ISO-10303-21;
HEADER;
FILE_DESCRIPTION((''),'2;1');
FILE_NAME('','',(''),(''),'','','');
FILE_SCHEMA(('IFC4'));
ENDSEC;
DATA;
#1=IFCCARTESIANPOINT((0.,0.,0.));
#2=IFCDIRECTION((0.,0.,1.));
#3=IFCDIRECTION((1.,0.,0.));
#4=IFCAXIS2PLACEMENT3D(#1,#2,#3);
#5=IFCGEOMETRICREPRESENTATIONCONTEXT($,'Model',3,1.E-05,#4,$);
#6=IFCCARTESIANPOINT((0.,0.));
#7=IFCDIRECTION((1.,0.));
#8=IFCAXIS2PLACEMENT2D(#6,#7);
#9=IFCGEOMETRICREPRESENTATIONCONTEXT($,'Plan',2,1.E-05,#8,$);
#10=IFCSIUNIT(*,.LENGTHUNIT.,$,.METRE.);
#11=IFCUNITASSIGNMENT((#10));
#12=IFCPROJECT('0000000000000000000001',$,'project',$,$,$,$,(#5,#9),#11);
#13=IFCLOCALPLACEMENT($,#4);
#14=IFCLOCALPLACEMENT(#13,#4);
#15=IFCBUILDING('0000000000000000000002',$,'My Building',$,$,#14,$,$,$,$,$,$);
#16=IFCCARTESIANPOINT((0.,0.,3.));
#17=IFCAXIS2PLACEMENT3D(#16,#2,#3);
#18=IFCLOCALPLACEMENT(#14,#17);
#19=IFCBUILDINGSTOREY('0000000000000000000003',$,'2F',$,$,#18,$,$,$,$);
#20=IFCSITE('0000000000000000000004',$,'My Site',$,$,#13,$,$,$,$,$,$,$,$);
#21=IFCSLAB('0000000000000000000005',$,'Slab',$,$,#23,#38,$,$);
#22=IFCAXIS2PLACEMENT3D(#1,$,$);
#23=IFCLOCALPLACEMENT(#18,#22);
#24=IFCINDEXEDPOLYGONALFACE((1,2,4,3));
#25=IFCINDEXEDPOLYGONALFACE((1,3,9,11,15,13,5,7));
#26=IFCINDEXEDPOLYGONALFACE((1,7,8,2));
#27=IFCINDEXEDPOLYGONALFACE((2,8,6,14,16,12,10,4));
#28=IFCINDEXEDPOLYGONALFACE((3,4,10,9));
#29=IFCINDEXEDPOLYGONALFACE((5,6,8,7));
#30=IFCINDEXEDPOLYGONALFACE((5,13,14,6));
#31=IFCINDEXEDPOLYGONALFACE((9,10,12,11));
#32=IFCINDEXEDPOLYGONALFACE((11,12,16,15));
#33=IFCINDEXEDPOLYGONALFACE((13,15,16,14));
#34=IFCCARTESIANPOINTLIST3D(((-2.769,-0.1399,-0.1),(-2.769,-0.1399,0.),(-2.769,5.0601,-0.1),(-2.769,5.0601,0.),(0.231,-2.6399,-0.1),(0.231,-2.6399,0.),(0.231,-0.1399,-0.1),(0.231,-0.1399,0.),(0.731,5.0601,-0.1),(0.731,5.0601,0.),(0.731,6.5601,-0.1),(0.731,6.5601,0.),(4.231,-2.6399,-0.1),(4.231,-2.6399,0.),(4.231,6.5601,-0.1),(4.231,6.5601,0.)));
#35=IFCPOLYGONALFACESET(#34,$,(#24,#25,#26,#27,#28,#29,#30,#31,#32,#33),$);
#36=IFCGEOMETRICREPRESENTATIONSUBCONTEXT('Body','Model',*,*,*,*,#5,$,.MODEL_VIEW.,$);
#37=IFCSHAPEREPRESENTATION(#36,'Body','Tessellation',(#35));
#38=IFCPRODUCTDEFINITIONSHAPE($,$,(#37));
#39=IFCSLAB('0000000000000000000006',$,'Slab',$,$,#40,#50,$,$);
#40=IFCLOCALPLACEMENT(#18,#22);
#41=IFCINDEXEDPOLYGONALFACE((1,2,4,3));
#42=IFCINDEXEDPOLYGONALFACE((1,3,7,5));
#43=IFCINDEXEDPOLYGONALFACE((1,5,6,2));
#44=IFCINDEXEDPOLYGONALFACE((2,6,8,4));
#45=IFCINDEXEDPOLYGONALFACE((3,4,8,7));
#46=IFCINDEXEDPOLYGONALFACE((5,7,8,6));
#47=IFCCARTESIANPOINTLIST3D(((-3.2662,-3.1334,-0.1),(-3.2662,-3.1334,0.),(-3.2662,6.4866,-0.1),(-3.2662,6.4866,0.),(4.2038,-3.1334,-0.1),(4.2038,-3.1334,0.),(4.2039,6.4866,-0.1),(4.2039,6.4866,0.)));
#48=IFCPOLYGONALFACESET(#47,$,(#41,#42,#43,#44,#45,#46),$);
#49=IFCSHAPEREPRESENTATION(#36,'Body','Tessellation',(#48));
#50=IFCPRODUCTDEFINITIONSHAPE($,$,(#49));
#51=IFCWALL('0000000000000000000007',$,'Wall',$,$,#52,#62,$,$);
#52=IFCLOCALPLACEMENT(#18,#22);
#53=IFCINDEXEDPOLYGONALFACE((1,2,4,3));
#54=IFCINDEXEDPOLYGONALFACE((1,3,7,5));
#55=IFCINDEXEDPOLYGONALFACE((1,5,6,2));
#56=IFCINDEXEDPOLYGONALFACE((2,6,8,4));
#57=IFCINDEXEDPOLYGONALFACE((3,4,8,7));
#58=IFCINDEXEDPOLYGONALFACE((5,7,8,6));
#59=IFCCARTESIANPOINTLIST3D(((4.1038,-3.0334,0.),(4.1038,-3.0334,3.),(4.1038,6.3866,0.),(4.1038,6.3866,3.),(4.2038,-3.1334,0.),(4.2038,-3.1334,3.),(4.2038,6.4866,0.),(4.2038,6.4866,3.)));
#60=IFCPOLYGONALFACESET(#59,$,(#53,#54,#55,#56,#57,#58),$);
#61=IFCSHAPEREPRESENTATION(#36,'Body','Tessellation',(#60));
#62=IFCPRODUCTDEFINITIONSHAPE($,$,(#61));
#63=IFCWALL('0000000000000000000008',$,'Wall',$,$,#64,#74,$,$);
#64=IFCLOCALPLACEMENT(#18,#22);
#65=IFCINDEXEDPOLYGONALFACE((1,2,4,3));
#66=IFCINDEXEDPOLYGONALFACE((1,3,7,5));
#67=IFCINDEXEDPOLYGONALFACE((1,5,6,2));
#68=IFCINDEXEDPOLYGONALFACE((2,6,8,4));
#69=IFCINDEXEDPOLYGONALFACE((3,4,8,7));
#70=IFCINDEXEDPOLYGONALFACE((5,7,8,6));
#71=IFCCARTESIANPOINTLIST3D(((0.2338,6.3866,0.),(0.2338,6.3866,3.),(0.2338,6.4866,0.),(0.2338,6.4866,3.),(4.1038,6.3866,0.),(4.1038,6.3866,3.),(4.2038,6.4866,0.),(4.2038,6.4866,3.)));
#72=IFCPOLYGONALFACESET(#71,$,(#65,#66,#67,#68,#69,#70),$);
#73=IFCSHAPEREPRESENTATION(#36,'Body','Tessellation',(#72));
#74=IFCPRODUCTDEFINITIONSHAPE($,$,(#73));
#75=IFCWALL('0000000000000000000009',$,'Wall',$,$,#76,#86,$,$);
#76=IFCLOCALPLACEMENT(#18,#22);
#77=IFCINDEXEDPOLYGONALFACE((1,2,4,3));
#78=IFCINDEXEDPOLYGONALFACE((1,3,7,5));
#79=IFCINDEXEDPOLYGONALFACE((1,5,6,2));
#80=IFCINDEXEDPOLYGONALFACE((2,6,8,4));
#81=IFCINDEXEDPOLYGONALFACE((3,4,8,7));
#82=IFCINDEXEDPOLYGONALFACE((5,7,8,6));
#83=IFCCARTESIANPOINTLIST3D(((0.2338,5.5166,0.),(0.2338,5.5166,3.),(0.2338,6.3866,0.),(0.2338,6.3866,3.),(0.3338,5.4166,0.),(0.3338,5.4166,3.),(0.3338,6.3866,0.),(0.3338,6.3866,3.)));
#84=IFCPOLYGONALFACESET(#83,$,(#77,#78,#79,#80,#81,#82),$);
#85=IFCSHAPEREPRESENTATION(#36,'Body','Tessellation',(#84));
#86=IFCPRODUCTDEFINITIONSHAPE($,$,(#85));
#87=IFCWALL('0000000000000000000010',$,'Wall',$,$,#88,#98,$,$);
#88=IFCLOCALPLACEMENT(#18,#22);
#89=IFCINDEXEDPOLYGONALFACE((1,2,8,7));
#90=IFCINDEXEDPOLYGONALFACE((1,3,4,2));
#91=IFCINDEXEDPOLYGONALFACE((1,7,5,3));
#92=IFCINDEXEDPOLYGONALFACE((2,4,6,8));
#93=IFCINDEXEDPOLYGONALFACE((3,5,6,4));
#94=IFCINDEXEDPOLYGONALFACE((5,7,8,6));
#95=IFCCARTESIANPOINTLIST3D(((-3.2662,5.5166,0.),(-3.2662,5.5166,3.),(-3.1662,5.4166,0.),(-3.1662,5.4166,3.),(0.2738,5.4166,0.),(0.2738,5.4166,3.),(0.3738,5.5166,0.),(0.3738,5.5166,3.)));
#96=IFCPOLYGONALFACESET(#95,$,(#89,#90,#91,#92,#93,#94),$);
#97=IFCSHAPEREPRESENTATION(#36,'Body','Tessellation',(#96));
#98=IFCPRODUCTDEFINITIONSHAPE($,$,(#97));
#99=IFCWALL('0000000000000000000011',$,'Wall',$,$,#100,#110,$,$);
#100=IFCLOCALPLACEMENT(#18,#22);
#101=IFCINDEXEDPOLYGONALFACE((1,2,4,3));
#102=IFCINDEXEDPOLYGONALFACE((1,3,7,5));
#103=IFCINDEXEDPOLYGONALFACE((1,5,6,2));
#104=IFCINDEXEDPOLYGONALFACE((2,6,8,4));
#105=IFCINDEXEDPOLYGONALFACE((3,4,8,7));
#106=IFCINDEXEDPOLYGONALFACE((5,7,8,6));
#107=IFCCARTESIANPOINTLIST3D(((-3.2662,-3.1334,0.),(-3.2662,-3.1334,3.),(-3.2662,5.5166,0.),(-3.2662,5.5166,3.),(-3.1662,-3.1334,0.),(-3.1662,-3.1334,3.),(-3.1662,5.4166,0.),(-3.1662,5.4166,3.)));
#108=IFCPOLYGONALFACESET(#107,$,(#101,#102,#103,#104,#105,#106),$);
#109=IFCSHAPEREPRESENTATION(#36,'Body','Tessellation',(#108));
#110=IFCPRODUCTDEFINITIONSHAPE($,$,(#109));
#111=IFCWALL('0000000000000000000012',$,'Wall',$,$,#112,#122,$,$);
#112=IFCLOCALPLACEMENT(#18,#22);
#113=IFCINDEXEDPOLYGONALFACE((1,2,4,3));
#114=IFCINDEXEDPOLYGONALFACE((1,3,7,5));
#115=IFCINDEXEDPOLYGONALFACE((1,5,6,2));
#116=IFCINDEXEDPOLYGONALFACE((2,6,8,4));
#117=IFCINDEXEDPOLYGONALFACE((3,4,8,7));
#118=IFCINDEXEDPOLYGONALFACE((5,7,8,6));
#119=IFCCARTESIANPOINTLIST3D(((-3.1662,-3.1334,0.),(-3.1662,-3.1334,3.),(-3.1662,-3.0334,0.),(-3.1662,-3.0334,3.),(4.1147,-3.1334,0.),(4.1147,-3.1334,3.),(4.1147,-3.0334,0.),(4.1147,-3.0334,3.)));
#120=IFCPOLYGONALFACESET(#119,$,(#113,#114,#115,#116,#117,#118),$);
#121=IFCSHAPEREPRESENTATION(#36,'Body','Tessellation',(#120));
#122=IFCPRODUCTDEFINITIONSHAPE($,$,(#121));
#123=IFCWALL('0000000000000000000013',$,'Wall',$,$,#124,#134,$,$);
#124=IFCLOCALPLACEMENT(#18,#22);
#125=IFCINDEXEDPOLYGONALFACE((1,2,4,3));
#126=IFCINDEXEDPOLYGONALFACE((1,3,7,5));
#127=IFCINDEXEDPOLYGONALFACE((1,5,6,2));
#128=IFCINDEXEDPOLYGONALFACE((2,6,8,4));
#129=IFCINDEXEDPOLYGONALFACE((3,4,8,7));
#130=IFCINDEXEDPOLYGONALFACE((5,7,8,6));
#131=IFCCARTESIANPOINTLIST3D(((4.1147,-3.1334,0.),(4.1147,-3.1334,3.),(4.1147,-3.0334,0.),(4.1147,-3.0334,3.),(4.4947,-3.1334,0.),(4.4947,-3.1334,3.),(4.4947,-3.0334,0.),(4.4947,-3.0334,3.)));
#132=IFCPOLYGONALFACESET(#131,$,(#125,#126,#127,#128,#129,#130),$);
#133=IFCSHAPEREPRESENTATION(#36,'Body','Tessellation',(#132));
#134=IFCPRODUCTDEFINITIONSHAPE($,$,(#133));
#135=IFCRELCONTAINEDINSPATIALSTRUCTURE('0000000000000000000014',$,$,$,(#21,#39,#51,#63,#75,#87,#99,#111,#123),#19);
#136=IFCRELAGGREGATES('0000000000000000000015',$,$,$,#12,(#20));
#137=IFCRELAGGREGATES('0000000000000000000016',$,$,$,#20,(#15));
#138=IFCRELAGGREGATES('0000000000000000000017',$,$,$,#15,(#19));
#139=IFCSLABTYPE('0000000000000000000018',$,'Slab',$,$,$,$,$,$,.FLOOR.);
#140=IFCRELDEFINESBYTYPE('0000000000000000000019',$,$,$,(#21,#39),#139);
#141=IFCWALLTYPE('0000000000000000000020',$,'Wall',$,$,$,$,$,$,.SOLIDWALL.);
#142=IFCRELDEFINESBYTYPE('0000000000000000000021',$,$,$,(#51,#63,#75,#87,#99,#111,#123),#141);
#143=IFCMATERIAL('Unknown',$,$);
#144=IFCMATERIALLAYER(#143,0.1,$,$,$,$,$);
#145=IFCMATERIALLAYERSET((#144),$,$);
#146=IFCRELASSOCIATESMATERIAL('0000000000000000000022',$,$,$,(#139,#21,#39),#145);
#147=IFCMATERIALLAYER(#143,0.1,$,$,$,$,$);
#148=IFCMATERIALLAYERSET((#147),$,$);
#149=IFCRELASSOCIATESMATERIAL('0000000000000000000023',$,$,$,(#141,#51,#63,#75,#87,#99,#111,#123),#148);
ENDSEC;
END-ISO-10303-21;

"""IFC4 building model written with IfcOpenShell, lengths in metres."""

from ifc_helpers import new_model, si_unit, frame, origin_with_axes, origin_2d_with_axis, place, context, subcontext, project, spatial, line, indexed_curve, outline, extrude, material, layer, layer_set, layer_usage, type_object, element, save


model = new_model("IFC4")

# Units and contexts
model_context = context("Model", 3, precision=1e-05, world=origin_with_axes())
plan_context = context("Plan", 2, precision=1e-05, world=origin_2d_with_axis())
body_context_1 = subcontext(model_context, "Body", "Model", "MODEL_VIEW")
ifc_project = project(units=[si_unit("LENGTHUNIT", "METRE")], contexts=[model_context, plan_context])

# Site, building, storey
site_placement = place(None, origin_with_axes())
site = spatial("IfcSite", under=ifc_project, at=site_placement, Name="My Site")
building_placement = place(site_placement, origin_with_axes())
building = spatial("IfcBuilding", under=site, at=building_placement, Name="My Building")
storey_placement = place(building_placement, frame((0.0, 0.0, 3.0), z_axis=(0.0, 0.0, 1.0), x_axis=(1.0, 0.0, 0.0)))
storey = spatial("IfcBuildingStorey", under=building, at=storey_placement, Name="2F")

# Slabs
ifc_material = material(Name="Unknown")
ifc_layer_1 = layer(ifc_material, 0.1)
ifc_layer_set_1 = layer_set([ifc_layer_1])
ifc_layer_usage_1 = layer_usage(ifc_layer_set_1, "AXIS3", "POSITIVE", -0.1)
slab_type = type_object("IfcSlabType", Name="Slab", PredefinedType="FLOOR", material=ifc_layer_set_1)
slab_1_placement = place(storey_placement, frame((0.231, -0.1399, 0.0), z_axis=(0.0, 0.0, 1.0), x_axis=(1.0, 0.0, 0.0)))
element("IfcSlab", 1, at=slab_1_placement, inside=storey, type_object=slab_type, material=ifc_layer_usage_1, Name="Slab", context=body_context_1, shape_type="SweptSolid", body=[
    extrude(outline(indexed_curve([(0.0, 0.0), (0.0, -2.5), (4.0, -2.5), (4.0, 6.7), (0.5, 6.7), (0.5, 5.2), (-3.0, 5.2), (-3.0, 0.0), (0.0, 0.0)])), frame((0.0, 0.0, -0.1), z_axis=(0.0, 0.0, 1.0), x_axis=(1.0, 0.0, 0.0)), (0.0, 0.0, 1.0), 0.1),
])
ifc_layer_usage_2 = layer_usage(ifc_layer_set_1, "AXIS3", "POSITIVE", -0.1)
slab_2_placement = place(storey_placement, frame((4.2038, -3.1334, 0.0), z_axis=(0.0, 0.0, 1.0), x_axis=(1.0, 0.0, 0.0)))
element("IfcSlab", 2, at=slab_2_placement, inside=storey, type_object=slab_type, material=ifc_layer_usage_2, Name="Slab", context=body_context_1, shape_type="SweptSolid", body=[
    extrude(outline(indexed_curve([(0.0, 0.0), (-7.47, 0.0), (-7.47, 9.62), (0.0, 9.62), (0.0, 0.0)])), frame((0.0, 0.0, -0.1), z_axis=(0.0, 0.0, 1.0), x_axis=(1.0, 0.0, 0.0)), (0.0, 0.0, 1.0), 0.1),
])

# Walls
ifc_layer_2 = layer(ifc_material, 0.1)
ifc_layer_set_2 = layer_set([ifc_layer_2])
ifc_layer_usage_3 = layer_usage(ifc_layer_set_2, "AXIS2", "POSITIVE", 0.0)
wall_type = type_object("IfcWallType", Name="Wall", PredefinedType="SOLIDWALL", material=ifc_layer_set_2)
wall_1_placement = place(storey_placement, frame((4.2038, -3.1334, 0.0), z_axis=(0.0, 0.0, 1.0), x_axis=(0.0, 1.0, 0.0)))
element("IfcWall", 3, at=wall_1_placement, inside=storey, type_object=wall_type, material=ifc_layer_usage_3, Name="Wall", context=body_context_1, shape_type="SweptSolid", body=[
    extrude(outline(indexed_curve([(0.0, 0.0), (0.1, 0.1), (9.52, 0.1), (9.62, 0.0)], segments=[line(1, 2, 3, 4, 1)])), origin_with_axes(), (0.0, 0.0, 1.0), 3.0),
])
ifc_layer_usage_4 = layer_usage(ifc_layer_set_2, "AXIS2", "POSITIVE", 0.0)
wall_2_placement = place(storey_placement, frame((4.2038, 6.4866, 0.0), z_axis=(0.0, 0.0, 1.0), x_axis=(-1.0, 0.0, 0.0)))
element("IfcWall", 4, at=wall_2_placement, inside=storey, type_object=wall_type, material=ifc_layer_usage_4, Name="Wall", context=body_context_1, shape_type="SweptSolid", body=[
    extrude(outline(indexed_curve([(0.0, 0.0), (0.1, 0.1), (3.97, 0.1), (3.97, 0.0)], segments=[line(1, 2, 3, 4, 1)])), origin_with_axes(), (0.0, 0.0, 1.0), 3.0),
])
ifc_layer_usage_5 = layer_usage(ifc_layer_set_2, "AXIS2", "POSITIVE", 0.0)
wall_3_placement = place(storey_placement, frame((0.2338, 6.3866, 0.0), z_axis=(0.0, 0.0, 1.0), x_axis=(0.0, -1.0, 0.0)))
element("IfcWall", 5, at=wall_3_placement, inside=storey, type_object=wall_type, material=ifc_layer_usage_5, Name="Wall", context=body_context_1, shape_type="SweptSolid", body=[
    extrude(outline(indexed_curve([(0.0, 0.0), (0.0, 0.1), (0.97, 0.1), (0.87, 0.0)], segments=[line(1, 2, 3, 4, 1)])), origin_with_axes(), (0.0, 0.0, 1.0), 3.0),
])
ifc_layer_usage_6 = layer_usage(ifc_layer_set_2, "AXIS2", "POSITIVE", 0.0)
wall_4_placement = place(storey_placement, frame((0.3738, 5.5166, 0.0), z_axis=(0.0, 0.0, 1.0), x_axis=(-1.0, 0.0, 0.0)))
element("IfcWall", 6, at=wall_4_placement, inside=storey, type_object=wall_type, material=ifc_layer_usage_6, Name="Wall", context=body_context_1, shape_type="SweptSolid", body=[
    extrude(outline(indexed_curve([(0.0, 0.0), (0.1, 0.1), (3.54, 0.1), (3.64, 0.0)], segments=[line(1, 2, 3, 4, 1)])), origin_with_axes(), (0.0, 0.0, 1.0), 3.0),
])
ifc_layer_usage_7 = layer_usage(ifc_layer_set_2, "AXIS2", "POSITIVE", 0.0)
wall_5_placement = place(storey_placement, frame((-3.2662, 5.5166, 0.0), z_axis=(0.0, 0.0, 1.0), x_axis=(0.0, -1.0, 0.0)))
element("IfcWall", 7, at=wall_5_placement, inside=storey, type_object=wall_type, material=ifc_layer_usage_7, Name="Wall", context=body_context_1, shape_type="SweptSolid", body=[
    extrude(outline(indexed_curve([(0.0, 0.0), (0.1, 0.1), (8.65, 0.1), (8.65, 0.0)], segments=[line(1, 2, 3, 4, 1)])), origin_with_axes(), (0.0, 0.0, 1.0), 3.0),
])
ifc_layer_usage_8 = layer_usage(ifc_layer_set_2, "AXIS2", "POSITIVE", 0.0)
wall_6_placement = place(storey_placement, frame((-3.1662, -3.1334, 0.0), z_axis=(0.0, 0.0, 1.0), x_axis=(1.0, 0.0, 0.0)))
element("IfcWall", 8, at=wall_6_placement, inside=storey, type_object=wall_type, material=ifc_layer_usage_8, Name="Wall", context=body_context_1, shape_type="SweptSolid", body=[
    extrude(outline(indexed_curve([(0.0, 0.0), (0.0, 0.1), (7.2809, 0.1), (7.2809, 0.0)], segments=[line(1, 2, 3, 4, 1)])), origin_with_axes(), (0.0, 0.0, 1.0), 3.0),
])
ifc_layer_usage_9 = layer_usage(ifc_layer_set_2, "AXIS2", "POSITIVE", 0.0)
wall_7_placement = place(storey_placement, frame((4.1147, -3.1334, 0.0), z_axis=(0.0, 0.0, 1.0), x_axis=(1.0, 0.0, 0.0)))
element("IfcWall", 9, at=wall_7_placement, inside=storey, type_object=wall_type, material=ifc_layer_usage_9, Name="Wall", context=body_context_1, shape_type="SweptSolid", body=[
    extrude(outline(indexed_curve([(0.0, 0.0), (0.0, 0.1), (0.38, 0.1), (0.38, 0.0)], segments=[line(1, 2, 3, 4, 1)])), origin_with_axes(), (0.0, 0.0, 1.0), 3.0),
])

save(model, "model.ifc")
